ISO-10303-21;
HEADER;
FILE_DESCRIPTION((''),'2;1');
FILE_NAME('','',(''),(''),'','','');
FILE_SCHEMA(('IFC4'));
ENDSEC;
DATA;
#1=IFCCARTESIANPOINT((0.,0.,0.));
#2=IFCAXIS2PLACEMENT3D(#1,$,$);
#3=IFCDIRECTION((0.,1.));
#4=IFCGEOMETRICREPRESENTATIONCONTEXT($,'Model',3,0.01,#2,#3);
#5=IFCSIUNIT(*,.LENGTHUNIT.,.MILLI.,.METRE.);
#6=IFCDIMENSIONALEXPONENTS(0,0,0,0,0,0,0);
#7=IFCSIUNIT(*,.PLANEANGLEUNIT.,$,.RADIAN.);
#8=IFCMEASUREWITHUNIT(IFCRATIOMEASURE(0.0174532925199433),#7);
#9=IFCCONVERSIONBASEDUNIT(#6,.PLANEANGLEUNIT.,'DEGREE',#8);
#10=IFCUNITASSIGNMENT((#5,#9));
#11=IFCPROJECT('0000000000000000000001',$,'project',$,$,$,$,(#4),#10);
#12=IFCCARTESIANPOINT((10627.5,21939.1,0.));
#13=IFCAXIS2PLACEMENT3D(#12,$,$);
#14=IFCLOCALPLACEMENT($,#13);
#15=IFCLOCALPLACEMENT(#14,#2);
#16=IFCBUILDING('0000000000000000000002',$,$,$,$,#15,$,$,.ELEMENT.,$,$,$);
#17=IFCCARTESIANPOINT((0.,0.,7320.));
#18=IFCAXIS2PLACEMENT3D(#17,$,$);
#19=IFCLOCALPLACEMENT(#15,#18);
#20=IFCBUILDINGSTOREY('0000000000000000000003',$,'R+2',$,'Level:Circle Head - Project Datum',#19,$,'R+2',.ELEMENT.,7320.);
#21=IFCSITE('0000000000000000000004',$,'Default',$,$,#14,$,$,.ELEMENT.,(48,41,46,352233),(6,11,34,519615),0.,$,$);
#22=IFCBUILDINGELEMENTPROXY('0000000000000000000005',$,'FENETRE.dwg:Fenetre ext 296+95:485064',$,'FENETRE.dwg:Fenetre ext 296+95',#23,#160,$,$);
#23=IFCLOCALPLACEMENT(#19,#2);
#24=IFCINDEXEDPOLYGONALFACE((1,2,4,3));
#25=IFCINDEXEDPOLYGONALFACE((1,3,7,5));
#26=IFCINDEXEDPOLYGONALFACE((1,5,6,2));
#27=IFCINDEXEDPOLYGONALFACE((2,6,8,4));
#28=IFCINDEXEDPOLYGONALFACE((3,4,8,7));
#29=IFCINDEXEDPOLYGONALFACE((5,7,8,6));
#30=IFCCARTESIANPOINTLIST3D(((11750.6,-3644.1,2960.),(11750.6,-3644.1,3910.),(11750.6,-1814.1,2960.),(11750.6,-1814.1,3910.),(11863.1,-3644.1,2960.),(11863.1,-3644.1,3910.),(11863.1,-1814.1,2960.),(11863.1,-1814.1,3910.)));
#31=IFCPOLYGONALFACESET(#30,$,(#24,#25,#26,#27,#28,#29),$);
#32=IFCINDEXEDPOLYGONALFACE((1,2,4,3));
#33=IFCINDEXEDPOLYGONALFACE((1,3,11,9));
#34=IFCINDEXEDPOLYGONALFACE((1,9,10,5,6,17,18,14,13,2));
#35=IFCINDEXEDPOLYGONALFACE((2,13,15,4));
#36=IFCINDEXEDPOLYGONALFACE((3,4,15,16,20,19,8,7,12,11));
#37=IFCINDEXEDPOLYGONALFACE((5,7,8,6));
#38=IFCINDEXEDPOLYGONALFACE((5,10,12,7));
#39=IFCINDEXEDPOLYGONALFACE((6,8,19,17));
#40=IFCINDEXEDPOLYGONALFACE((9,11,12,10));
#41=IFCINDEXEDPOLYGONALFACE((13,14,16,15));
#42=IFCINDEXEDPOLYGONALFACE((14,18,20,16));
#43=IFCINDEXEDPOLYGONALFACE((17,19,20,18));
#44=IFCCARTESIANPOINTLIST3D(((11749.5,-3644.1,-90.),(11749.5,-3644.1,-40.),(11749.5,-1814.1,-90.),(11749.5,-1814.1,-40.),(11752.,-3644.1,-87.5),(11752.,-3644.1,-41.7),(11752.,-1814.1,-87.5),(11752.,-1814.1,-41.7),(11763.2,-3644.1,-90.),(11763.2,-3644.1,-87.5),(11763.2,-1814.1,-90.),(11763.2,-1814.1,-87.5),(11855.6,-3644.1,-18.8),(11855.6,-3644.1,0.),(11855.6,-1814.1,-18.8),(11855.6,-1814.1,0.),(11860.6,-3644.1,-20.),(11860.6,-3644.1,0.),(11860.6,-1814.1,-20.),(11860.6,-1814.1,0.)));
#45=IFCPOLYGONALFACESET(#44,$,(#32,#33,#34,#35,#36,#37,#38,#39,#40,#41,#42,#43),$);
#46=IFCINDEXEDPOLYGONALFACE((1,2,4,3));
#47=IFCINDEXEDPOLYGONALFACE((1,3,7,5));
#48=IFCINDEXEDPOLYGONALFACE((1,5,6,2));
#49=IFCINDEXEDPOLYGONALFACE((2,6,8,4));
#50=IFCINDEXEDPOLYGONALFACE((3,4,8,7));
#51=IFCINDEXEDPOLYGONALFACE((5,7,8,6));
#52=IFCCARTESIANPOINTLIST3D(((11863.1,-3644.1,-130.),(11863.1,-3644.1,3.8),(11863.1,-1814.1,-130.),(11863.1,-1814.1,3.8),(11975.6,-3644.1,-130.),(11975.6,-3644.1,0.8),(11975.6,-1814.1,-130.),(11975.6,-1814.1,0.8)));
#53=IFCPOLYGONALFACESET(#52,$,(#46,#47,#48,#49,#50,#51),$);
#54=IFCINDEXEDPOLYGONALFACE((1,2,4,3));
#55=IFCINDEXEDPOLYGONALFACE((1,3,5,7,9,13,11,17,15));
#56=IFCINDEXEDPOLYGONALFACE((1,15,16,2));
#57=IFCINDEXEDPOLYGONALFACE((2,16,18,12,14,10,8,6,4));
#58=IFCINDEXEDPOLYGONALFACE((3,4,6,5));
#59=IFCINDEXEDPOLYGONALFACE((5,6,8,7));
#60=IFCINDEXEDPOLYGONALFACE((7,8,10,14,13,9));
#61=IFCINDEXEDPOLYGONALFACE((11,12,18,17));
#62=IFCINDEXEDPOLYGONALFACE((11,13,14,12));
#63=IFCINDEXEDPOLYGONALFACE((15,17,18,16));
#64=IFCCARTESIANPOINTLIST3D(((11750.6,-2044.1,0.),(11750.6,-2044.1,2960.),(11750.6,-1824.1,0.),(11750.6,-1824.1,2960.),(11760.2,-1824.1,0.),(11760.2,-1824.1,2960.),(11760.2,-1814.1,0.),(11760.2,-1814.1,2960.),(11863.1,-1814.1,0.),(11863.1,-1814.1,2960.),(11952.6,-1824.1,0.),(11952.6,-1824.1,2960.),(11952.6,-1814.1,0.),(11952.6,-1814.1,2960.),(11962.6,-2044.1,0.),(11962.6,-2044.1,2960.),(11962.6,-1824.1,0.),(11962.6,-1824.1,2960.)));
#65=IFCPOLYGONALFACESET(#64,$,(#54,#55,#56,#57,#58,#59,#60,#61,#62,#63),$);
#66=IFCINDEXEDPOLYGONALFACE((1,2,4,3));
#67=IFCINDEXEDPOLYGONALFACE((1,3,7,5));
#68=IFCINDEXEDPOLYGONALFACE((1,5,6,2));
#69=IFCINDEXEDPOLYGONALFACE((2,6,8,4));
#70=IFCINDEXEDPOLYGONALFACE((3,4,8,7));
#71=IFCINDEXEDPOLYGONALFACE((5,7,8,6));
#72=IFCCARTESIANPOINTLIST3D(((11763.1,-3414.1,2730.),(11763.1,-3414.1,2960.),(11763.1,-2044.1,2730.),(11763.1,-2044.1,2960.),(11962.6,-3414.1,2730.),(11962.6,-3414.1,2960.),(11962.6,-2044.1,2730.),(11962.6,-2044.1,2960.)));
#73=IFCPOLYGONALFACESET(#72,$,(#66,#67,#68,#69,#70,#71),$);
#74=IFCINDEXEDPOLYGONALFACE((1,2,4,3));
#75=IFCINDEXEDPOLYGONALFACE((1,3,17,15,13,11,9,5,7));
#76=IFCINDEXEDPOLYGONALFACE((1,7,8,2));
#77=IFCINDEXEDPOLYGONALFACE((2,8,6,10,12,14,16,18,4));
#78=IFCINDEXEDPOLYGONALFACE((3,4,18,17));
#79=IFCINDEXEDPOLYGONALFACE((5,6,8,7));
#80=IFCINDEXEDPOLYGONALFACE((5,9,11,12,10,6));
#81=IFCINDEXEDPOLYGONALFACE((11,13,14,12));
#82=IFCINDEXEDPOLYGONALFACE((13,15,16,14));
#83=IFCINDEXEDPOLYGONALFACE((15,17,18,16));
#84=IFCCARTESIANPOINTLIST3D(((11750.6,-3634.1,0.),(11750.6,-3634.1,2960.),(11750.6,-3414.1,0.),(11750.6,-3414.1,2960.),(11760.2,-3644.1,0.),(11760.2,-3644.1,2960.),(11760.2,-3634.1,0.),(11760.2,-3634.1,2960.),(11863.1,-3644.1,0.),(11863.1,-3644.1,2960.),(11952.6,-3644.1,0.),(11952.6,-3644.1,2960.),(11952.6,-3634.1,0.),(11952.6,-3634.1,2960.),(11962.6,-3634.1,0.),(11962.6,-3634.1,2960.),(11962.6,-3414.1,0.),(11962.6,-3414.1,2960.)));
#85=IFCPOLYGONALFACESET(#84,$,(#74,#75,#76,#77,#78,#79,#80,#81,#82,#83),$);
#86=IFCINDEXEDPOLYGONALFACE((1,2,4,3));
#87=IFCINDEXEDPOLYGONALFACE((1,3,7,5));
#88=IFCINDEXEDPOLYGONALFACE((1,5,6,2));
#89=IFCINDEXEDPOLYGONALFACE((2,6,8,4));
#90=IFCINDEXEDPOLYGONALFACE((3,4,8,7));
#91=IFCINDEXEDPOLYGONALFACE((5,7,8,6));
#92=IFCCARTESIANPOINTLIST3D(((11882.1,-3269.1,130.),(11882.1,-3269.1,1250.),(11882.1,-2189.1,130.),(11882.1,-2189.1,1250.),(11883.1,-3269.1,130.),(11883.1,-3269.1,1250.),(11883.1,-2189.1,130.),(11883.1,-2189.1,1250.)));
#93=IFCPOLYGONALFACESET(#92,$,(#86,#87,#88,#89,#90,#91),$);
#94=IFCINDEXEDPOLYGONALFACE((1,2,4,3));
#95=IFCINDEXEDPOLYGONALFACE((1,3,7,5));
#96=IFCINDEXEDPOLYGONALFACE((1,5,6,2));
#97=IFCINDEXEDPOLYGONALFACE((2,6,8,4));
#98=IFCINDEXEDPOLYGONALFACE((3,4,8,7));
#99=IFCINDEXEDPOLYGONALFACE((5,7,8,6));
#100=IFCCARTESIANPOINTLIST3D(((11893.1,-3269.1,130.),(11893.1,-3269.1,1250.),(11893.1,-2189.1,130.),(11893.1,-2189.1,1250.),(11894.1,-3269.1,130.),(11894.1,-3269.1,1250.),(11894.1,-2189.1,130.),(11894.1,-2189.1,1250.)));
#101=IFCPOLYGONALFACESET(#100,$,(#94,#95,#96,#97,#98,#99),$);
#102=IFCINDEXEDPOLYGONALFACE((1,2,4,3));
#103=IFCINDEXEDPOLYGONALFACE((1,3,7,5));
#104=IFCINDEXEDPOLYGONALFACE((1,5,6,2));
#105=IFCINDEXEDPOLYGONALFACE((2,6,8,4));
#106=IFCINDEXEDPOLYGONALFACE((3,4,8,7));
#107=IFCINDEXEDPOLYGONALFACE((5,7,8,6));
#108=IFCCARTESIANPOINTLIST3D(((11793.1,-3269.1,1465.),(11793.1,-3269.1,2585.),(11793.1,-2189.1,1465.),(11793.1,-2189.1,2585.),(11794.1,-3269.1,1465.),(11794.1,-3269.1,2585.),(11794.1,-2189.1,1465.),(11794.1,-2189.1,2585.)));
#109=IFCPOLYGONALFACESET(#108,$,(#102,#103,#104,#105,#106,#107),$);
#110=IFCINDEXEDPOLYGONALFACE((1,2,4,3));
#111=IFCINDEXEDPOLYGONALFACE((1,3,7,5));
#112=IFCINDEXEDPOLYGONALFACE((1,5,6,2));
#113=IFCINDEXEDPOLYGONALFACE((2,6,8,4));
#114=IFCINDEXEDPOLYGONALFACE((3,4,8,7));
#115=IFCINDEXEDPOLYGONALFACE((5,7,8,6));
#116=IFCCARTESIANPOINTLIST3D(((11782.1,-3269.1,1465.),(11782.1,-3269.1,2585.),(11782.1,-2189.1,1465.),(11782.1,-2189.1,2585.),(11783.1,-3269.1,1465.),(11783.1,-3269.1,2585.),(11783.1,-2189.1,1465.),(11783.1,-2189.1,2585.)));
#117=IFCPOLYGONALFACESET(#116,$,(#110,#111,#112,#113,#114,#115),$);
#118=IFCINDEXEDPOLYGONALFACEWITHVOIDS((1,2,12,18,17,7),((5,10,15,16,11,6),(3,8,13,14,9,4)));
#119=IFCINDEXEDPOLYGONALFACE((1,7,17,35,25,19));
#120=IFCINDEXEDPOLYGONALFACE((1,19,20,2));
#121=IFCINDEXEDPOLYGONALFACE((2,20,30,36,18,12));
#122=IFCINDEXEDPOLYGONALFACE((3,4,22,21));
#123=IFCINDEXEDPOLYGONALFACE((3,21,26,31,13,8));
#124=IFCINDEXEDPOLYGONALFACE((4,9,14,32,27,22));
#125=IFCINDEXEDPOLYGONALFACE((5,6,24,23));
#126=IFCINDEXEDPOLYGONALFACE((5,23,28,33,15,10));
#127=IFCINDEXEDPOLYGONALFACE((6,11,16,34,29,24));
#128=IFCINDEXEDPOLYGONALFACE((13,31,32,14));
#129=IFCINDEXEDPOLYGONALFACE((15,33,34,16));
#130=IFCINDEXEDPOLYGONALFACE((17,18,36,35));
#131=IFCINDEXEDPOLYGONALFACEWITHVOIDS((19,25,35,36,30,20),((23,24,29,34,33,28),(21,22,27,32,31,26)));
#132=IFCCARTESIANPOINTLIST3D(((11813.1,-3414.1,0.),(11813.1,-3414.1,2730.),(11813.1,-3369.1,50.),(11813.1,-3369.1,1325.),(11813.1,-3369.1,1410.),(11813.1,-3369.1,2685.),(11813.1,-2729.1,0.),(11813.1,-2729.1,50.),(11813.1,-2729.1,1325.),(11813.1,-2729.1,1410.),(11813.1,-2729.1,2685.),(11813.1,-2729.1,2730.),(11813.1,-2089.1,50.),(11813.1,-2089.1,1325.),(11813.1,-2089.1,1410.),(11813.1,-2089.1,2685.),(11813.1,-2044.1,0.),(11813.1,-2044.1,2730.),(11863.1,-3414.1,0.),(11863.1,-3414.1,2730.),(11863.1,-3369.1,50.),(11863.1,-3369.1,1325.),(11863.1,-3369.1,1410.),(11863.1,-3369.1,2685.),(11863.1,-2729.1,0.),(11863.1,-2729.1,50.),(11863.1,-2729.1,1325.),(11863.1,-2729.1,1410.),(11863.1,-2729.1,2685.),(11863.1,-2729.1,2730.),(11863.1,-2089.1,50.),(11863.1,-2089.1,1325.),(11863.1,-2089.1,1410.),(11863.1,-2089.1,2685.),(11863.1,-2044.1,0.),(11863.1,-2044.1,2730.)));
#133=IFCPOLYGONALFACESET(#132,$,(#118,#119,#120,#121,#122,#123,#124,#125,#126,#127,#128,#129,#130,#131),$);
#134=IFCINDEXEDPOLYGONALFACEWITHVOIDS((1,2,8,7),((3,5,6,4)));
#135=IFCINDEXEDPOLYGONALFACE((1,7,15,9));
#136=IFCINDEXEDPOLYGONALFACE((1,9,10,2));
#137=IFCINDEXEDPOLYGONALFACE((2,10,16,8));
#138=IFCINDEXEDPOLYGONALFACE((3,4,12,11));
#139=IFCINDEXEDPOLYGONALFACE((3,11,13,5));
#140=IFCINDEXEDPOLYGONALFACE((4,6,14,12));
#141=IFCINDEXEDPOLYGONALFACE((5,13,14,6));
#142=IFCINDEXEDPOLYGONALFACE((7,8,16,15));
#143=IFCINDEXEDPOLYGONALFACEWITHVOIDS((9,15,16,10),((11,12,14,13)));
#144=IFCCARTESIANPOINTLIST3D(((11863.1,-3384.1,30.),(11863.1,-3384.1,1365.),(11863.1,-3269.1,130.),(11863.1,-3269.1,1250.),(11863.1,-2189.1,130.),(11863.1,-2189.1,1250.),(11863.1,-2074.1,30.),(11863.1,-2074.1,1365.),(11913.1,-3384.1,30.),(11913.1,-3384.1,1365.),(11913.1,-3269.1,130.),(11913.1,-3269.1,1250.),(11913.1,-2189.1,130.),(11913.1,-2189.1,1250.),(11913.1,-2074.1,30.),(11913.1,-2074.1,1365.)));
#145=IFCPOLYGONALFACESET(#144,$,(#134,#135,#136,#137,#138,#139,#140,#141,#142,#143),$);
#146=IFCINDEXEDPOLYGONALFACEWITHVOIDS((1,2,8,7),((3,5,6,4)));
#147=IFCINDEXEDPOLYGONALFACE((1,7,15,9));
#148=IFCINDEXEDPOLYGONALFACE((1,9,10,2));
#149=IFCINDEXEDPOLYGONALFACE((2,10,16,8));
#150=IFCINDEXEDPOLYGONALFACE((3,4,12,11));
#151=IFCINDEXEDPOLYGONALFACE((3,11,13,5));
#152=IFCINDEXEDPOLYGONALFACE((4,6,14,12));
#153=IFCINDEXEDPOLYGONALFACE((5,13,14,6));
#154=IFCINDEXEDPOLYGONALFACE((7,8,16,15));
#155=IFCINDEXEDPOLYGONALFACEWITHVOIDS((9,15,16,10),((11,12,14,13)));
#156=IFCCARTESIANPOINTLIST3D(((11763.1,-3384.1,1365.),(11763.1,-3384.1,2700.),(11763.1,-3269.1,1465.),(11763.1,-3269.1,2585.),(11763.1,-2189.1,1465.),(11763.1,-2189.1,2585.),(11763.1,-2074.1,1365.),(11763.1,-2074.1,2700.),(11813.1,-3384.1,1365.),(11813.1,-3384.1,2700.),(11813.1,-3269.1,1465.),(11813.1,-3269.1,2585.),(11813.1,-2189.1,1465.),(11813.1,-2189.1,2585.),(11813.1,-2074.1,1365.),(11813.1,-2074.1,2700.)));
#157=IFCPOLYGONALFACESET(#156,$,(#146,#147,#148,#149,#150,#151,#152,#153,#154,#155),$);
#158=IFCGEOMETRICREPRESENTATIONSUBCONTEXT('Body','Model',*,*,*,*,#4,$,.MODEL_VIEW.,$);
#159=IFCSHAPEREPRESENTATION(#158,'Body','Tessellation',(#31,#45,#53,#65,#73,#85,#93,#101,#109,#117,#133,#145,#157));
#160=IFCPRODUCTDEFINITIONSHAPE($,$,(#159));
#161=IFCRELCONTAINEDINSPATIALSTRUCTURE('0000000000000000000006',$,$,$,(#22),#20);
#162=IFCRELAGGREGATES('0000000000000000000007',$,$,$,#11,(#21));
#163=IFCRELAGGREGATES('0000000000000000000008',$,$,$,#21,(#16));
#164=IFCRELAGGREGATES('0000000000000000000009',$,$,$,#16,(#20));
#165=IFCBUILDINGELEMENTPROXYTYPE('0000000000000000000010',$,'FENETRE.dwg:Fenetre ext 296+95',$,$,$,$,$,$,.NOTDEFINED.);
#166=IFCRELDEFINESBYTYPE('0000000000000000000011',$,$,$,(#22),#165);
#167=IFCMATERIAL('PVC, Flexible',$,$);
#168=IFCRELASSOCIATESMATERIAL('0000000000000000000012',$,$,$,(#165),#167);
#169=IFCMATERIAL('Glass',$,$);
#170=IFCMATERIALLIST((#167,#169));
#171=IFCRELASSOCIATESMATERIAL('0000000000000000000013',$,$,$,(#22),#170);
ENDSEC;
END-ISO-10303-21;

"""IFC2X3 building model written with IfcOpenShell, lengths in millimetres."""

from ifc_helpers import new_model, entity, si_unit, converted_unit, direction, frame, frame_2d, origin, origin_2d_with_axis, place, context, subcontext, project, spatial, polyline, rectangle, outline, extrude, source, transform, mapped, material, material_list, type_object, type_shapes, element, save


model = new_model("IFC2X3")

# Units and contexts
model_context = context("Model", 3, precision=0.01, world=origin(), true_north=direction((0.0, 1.0)))
body_context = subcontext(model_context, "Body", "Model", "MODEL_VIEW")
ifc_project = project(units=[si_unit("LENGTHUNIT", "METRE", prefix="MILLI"), converted_unit("PLANEANGLEUNIT", "DEGREE", entity("IfcRatioMeasure", 0.0174532925199433), si_unit("PLANEANGLEUNIT", "RADIAN"), dimensions=[0, 0, 0, 0, 0, 0, 0])], contexts=[model_context])

# Site, building, storey
site_placement = place(None, frame((10627.5, 21939.1, 0.0)))
site = spatial("IfcSite", under=ifc_project, at=site_placement, Name="Default", CompositionType="ELEMENT", RefLatitude=(48, 41, 46, 352233), RefLongitude=(6, 11, 34, 519615), RefElevation=0.0)
building_placement = place(site_placement, origin())
building = spatial("IfcBuilding", under=site, at=building_placement, CompositionType="ELEMENT")
storey_placement = place(building_placement, frame((0.0, 0.0, 7320.0)))
storey = spatial("IfcBuildingStorey", under=building, at=storey_placement, Name="R+2", ObjectType="Level:Circle Head - Project Datum", LongName="R+2", CompositionType="ELEMENT", Elevation=7320.0)

# Building element proxy
ifc_material_1 = material(Name="PVC, Flexible")
ifc_material_2 = material(Name="Glass")
building_element_proxy_type_1 = type_object("IfcBuildingElementProxyType", Name="FENETRE.dwg:Fenetre ext 296+95", PredefinedType="NOTDEFINED", material=ifc_material_1)
shared_shape_1 = source(origin(), body_context, "Body", "SweptSolid", [
    extrude(rectangle(XDim=1830.0, YDim=112.5, at=origin_2d_with_axis()), frame((-10.4, 56.3, 2960.0), z_axis=(0.0, 0.0, 1.0), x_axis=(-1.0, 0.0, 0.0)), (0.0, 0.0, 1.0), 950.0),
    extrude(outline(polyline([(-68.6, -14.4), (-72.5, -34.0), (-67.6, -35.0), (-63.9, -16.6), (44.3, -16.6), (54.1, 32.5), (40.6, 35.2), (40.1, 32.7), (51.2, 30.5), (42.2, -14.4), (-68.6, -14.4)])), frame((-925.4, 66.9, -47.5), z_axis=(-1.0, 0.0, 0.0), x_axis=(0.0, 0.980599, -0.196027)), (0.0, 0.0, -1.0), 1830.0),
    extrude(outline(polyline([(-64.7, -56.3), (66.2, -56.3), (66.2, 56.3), (-67.7, 56.3), (-64.7, -56.3)])), frame((-925.4, -56.3, -63.8), z_axis=(1.0, 0.0, 0.0), x_axis=(0.0, 0.0, -1.0)), (0.0, 0.0, 1.0), 1830.0),
    extrude(outline(polyline([(-55.6, 97.0), (-55.6, -5.9), (-55.6, -95.4), (-45.6, -95.4), (-45.6, -105.4), (174.4, -105.4), (174.4, 106.6), (-45.6, 106.6), (-45.6, 97.0), (-55.6, 97.0)])), frame((849.0, 5.9, 0.0), z_axis=(0.0, 0.0, -1.0), x_axis=(-1.0, 0.0, 0.0)), (0.0, 0.0, -1.0), 2960.0),
    extrude(rectangle(XDim=199.5, YDim=1370.0, at=origin_2d_with_axis()), frame((-10.4, 0.3, 2730.0), z_axis=(0.0, 0.0, 1.0), x_axis=(0.0, 1.0, 0.0)), (0.0, 0.0, 1.0), 230.0),
    extrude(outline(polyline([(-97.0, -55.6), (5.9, -55.6), (95.4, -55.6), (95.4, -45.6), (105.4, -45.6), (105.4, 174.4), (-106.6, 174.4), (-106.6, -45.6), (-97.0, -45.6), (-97.0, -55.6)])), frame((-869.9, 5.9, 0.0), z_axis=(0.0, 0.0, 1.0), x_axis=(0.0, -1.0, 0.0)), (0.0, 0.0, 1.0), 2960.0),
    extrude(rectangle(XDim=1.0, YDim=1080.0, at=origin_2d_with_axis()), frame((-10.4, -19.5, 130.0), z_axis=(0.0, 0.0, 1.0), x_axis=(0.0, 1.0, 0.0)), (0.0, 0.0, 1.0), 1120.0),
    extrude(rectangle(XDim=1.0, YDim=1080.0, at=frame_2d((0.0, 0.0), x_axis=(1.0, 0.0))), frame((-10.4, -30.5, 130.0), z_axis=(0.0, 0.0, 1.0), x_axis=(0.0, 1.0, 0.0)), (0.0, 0.0, 1.0), 1120.0),
    extrude(rectangle(XDim=1.0, YDim=1080.0, at=frame_2d((0.0, 0.0), x_axis=(1.0, 0.0))), frame((-10.4, 69.5, 1465.0), z_axis=(0.0, 0.0, 1.0), x_axis=(0.0, 1.0, 0.0)), (0.0, 0.0, 1.0), 1120.0),
    extrude(rectangle(XDim=1.0, YDim=1080.0, at=frame_2d((0.0, 0.0), x_axis=(1.0, 0.0))), frame((-10.4, 80.5, 1465.0), z_axis=(0.0, 0.0, 1.0), x_axis=(0.0, 1.0, 0.0)), (0.0, 0.0, 1.0), 1120.0),
    extrude(outline(polyline([(-685.0, -1365.0), (0.0, -1365.0), (685.0, -1365.0), (685.0, 1365.0), (0.0, 1365.0), (-685.0, 1365.0), (-685.0, -1365.0)]), holes=[polyline([(-640.0, -1320.0), (-640.0, -45.0), (0.0, -45.0), (640.0, -45.0), (640.0, -1320.0), (0.0, -1320.0), (-640.0, -1320.0)]), polyline([(-640.0, 40.0), (-640.0, 1315.0), (0.0, 1315.0), (640.0, 1315.0), (640.0, 40.0), (0.0, 40.0), (-640.0, 40.0)])]), frame((-10.4, 0.0, 1365.0), z_axis=(0.0, 1.0, 0.0), x_axis=(1.0, 0.0, 0.0)), (0.0, 0.0, 1.0), 50.0),
    extrude(outline(polyline([(-655.0, -667.5), (655.0, -667.5), (655.0, 667.5), (-655.0, 667.5), (-655.0, -667.5)]), holes=[polyline([(-540.0, 552.5), (540.0, 552.5), (540.0, -567.5), (-540.0, -567.5), (-540.0, 552.5)])]), frame((-10.4, -50.0, 697.5), z_axis=(0.0, 1.0, 0.0), x_axis=(-1.0, 0.0, 0.0)), (0.0, 0.0, 1.0), 50.0),
    extrude(outline(polyline([(-655.0, -667.5), (655.0, -667.5), (655.0, 667.5), (-655.0, 667.5), (-655.0, -667.5)]), holes=[polyline([(-540.0, 552.5), (540.0, 552.5), (540.0, -567.5), (-540.0, -567.5), (-540.0, 552.5)])]), frame((-10.4, 50.0, 2032.5), z_axis=(0.0, 1.0, 0.0), x_axis=(-1.0, 0.0, 0.0)), (0.0, 0.0, 1.0), 50.0),
])
type_shapes(building_element_proxy_type_1, [shared_shape_1])
ifc_material_list_1 = material_list([ifc_material_1, ifc_material_2])
proxy_1_placement = place(storey_placement, frame((11863.1, -2718.7, 0.0), z_axis=(0.0, 0.0, 1.0), x_axis=(0.0, 1.0, 0.0)))
element("IfcBuildingElementProxy", 1, at=proxy_1_placement, inside=storey, type_object=building_element_proxy_type_1, material=ifc_material_list_1, Name="FENETRE.dwg:Fenetre ext 296+95:485064", ObjectType="FENETRE.dwg:Fenetre ext 296+95", context=body_context, shape_type="MappedRepresentation", body=[
    mapped(shared_shape_1, transform((0.0, 0.0, 0.0), scale=1.0)),
])

save(model, "model.ifc")
